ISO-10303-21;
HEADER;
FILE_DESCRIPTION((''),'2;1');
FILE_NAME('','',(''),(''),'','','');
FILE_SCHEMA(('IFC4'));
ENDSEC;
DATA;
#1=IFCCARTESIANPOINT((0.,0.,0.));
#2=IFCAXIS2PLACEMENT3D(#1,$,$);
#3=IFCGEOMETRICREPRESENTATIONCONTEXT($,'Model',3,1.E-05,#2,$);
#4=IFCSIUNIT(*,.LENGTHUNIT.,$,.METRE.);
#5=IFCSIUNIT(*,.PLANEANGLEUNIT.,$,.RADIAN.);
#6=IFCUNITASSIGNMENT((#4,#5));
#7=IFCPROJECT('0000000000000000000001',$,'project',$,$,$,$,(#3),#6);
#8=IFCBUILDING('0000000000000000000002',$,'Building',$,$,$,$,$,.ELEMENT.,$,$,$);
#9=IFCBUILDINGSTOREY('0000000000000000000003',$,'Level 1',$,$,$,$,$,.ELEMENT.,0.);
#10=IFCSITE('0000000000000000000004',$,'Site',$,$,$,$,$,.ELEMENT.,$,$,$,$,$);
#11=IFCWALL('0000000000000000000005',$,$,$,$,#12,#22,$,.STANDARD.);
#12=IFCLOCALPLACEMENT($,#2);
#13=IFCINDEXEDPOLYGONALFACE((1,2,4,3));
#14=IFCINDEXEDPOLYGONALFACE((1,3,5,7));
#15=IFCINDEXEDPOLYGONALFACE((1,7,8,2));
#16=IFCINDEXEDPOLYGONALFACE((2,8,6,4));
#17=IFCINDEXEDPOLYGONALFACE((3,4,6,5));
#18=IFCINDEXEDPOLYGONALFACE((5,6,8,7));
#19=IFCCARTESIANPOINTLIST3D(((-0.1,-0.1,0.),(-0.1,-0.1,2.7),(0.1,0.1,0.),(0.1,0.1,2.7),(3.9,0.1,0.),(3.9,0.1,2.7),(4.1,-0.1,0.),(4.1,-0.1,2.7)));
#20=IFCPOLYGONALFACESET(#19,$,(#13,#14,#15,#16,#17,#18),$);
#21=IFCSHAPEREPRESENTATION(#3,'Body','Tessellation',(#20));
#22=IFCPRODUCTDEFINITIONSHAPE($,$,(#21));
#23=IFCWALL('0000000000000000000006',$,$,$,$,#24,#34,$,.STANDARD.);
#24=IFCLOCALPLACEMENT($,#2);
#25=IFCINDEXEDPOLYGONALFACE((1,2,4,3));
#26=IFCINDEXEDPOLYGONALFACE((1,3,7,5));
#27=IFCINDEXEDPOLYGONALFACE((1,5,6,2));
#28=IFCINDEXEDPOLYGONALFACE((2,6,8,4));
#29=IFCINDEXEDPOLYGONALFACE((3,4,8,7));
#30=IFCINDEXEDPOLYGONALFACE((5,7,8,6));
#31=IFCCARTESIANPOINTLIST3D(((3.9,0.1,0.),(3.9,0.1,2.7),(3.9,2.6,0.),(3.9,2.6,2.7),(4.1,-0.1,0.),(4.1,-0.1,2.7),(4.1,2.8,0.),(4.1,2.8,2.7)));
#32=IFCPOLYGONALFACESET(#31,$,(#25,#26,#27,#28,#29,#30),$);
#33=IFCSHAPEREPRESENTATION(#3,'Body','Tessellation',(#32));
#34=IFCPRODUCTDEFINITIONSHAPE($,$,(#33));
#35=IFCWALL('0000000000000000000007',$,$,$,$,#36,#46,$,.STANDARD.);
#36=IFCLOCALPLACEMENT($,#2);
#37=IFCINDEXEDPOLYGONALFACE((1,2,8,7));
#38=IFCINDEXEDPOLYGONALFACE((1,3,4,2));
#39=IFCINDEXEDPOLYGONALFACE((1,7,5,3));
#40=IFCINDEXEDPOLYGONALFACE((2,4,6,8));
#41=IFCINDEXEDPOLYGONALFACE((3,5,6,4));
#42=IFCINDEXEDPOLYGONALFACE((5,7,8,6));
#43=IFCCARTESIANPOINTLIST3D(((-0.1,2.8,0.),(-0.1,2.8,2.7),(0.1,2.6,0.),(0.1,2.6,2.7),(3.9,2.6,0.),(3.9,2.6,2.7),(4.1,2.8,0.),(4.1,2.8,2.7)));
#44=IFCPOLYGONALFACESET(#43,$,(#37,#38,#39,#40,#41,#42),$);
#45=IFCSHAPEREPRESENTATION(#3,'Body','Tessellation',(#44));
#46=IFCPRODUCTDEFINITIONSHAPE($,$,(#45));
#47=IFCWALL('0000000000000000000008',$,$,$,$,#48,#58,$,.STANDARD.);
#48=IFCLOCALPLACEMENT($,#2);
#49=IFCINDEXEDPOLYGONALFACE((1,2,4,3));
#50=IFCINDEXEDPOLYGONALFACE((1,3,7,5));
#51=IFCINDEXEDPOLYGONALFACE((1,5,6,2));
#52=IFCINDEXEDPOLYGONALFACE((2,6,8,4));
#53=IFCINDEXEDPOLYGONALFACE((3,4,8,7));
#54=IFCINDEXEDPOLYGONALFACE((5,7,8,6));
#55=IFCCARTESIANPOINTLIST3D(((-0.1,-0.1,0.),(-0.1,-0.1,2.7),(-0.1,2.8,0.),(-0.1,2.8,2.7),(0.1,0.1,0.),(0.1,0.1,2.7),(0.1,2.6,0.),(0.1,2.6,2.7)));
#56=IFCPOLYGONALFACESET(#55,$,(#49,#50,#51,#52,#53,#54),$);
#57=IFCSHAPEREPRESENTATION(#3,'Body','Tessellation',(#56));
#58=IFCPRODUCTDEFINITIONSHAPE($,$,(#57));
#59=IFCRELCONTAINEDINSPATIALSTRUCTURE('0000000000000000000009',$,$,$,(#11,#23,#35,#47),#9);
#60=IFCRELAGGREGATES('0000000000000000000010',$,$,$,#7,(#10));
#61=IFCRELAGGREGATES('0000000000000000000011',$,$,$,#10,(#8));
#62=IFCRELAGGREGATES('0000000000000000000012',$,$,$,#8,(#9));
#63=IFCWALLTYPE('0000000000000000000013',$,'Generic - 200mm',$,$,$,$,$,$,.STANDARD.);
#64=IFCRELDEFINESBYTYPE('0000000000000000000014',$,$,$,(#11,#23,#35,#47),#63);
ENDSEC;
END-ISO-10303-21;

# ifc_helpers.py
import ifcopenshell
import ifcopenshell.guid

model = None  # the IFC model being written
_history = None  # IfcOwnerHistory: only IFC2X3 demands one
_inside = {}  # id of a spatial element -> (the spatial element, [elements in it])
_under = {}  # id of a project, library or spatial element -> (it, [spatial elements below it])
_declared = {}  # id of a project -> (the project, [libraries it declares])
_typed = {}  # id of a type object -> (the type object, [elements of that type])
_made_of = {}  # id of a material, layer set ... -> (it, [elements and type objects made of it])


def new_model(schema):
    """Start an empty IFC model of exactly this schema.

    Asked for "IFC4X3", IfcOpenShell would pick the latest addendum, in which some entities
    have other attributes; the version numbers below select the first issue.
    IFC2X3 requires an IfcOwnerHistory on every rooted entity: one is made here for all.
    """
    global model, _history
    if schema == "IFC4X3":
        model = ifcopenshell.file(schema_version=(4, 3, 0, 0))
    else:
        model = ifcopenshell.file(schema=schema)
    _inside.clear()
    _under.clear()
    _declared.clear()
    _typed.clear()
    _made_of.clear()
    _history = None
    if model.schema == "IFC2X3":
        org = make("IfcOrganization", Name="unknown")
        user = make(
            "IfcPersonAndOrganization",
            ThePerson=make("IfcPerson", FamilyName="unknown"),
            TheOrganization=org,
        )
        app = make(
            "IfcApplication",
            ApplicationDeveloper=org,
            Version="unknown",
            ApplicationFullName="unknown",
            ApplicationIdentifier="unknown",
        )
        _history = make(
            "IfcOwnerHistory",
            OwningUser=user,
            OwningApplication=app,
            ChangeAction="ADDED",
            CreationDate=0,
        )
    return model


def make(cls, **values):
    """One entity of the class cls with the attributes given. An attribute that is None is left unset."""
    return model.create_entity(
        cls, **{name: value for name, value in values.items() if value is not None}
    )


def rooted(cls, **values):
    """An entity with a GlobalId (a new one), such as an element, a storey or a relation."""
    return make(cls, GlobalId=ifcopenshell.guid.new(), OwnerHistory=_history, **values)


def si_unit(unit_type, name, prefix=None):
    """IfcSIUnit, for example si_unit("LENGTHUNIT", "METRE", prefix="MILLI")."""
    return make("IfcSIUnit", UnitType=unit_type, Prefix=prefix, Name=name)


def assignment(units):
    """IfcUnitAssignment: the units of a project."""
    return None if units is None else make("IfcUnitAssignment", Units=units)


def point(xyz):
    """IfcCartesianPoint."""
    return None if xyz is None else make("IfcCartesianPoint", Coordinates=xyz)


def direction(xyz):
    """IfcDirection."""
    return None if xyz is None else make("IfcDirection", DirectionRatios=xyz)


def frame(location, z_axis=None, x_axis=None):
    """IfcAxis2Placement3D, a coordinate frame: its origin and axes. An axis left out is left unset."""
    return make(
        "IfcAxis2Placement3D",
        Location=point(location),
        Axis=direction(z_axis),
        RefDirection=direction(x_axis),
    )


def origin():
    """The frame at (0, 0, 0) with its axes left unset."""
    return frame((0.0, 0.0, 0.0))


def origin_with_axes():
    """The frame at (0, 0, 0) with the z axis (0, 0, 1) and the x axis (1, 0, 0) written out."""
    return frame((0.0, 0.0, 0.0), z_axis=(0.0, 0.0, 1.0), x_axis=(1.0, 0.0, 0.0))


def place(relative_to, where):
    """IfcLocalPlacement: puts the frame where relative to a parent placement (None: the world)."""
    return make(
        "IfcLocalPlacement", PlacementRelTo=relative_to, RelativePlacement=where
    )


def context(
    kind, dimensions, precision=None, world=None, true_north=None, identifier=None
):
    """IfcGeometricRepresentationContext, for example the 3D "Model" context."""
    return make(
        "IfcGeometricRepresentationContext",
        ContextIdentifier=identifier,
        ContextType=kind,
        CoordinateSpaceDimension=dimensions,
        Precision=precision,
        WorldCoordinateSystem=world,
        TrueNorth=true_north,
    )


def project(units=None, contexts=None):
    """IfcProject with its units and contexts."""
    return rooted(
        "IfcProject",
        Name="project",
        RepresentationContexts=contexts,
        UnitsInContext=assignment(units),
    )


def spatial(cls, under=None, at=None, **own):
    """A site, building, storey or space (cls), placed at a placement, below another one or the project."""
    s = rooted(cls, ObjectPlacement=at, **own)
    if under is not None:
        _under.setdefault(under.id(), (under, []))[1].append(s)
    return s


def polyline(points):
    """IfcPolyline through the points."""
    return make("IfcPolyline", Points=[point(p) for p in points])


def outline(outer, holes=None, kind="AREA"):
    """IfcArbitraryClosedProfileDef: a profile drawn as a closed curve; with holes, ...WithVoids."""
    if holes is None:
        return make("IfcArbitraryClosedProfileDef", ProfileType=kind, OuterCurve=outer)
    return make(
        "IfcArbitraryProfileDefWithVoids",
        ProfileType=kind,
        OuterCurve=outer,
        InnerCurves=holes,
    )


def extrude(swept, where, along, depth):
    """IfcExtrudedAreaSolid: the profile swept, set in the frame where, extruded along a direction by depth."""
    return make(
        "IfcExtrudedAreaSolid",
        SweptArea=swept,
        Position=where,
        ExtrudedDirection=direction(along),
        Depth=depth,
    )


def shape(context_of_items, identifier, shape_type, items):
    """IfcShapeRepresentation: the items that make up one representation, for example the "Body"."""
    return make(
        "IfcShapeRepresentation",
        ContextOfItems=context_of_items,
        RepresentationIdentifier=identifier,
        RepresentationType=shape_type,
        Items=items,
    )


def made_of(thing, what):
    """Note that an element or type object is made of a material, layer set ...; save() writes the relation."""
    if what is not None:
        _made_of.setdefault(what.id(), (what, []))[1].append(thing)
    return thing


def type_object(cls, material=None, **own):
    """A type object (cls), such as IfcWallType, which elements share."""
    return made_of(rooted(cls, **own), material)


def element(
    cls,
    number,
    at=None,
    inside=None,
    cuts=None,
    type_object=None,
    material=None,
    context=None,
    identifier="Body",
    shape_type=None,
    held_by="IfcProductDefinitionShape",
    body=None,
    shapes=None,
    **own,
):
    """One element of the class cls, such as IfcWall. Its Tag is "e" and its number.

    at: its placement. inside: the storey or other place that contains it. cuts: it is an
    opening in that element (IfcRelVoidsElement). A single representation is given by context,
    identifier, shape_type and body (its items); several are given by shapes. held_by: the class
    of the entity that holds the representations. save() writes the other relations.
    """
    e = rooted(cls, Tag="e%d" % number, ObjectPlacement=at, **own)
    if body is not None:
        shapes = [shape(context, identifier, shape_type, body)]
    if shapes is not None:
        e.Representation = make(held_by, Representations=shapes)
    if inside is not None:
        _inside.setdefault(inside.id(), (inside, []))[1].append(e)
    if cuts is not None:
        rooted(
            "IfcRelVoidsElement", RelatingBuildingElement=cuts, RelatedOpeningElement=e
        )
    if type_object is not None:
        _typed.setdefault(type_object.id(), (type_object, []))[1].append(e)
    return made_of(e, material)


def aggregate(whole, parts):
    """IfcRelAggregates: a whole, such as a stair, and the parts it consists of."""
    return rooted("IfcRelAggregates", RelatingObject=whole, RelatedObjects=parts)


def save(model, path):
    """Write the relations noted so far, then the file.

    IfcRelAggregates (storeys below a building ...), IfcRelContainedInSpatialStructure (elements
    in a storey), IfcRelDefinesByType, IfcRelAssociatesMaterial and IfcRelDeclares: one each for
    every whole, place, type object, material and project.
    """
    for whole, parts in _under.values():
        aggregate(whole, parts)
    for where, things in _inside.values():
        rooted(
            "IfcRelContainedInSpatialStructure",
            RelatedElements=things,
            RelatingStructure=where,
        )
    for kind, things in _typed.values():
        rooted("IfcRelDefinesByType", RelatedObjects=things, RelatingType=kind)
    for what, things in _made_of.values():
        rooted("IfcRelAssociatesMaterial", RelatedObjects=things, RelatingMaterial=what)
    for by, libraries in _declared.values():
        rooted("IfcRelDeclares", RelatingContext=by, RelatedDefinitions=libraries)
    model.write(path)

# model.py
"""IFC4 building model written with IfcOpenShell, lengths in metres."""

from ifc_helpers import new_model, si_unit, frame, origin, origin_with_axes, place, context, project, spatial, polyline, outline, extrude, type_object, element, save


model = new_model("IFC4")

# Units and contexts
model_context = context("Model", 3, precision=1e-05, world=origin())
ifc_project = project(units=[si_unit("LENGTHUNIT", "METRE"), si_unit("PLANEANGLEUNIT", "RADIAN")], contexts=[model_context])

# Site, building, storey
site = spatial("IfcSite", under=ifc_project, Name="Site", CompositionType="ELEMENT")
building = spatial("IfcBuilding", under=site, Name="Building", CompositionType="ELEMENT")
storey = spatial("IfcBuildingStorey", under=building, Name="Level 1", CompositionType="ELEMENT", Elevation=0.0)

# Walls
wall_type = type_object("IfcWallType", Name="Generic - 200mm", PredefinedType="STANDARD")
wall_1_placement = place(None, origin_with_axes())
element("IfcWall", 1, at=wall_1_placement, inside=storey, type_object=wall_type, PredefinedType="STANDARD", context=model_context, shape_type="SweptSolid", body=[
    extrude(outline(polyline([(-0.1, -0.1), (4.1, -0.1), (3.9, 0.1), (0.1, 0.1), (-0.1, -0.1)])), origin(), (0.0, 0.0, 1.0), 2.7),
])
wall_2_placement = place(None, frame((4.0, 0.0, 0.0), z_axis=(0.0, 0.0, 1.0), x_axis=(0.0, 1.0, 0.0)))
element("IfcWall", 2, at=wall_2_placement, inside=storey, type_object=wall_type, PredefinedType="STANDARD", context=model_context, shape_type="SweptSolid", body=[
    extrude(outline(polyline([(-0.1, -0.1), (2.8, -0.1), (2.6, 0.1), (0.1, 0.1), (-0.1, -0.1)])), origin(), (0.0, 0.0, 1.0), 2.7),
])
wall_3_placement = place(None, frame((4.0, 2.7, 0.0), z_axis=(0.0, 0.0, 1.0), x_axis=(-1.0, 0.0, 0.0)))
element("IfcWall", 3, at=wall_3_placement, inside=storey, type_object=wall_type, PredefinedType="STANDARD", context=model_context, shape_type="SweptSolid", body=[
    extrude(outline(polyline([(-0.1, -0.1), (4.1, -0.1), (3.9, 0.1), (0.1, 0.1), (-0.1, -0.1)])), origin(), (0.0, 0.0, 1.0), 2.7),
])
wall_4_placement = place(None, frame((0.0, 2.7, 0.0), z_axis=(0.0, 0.0, 1.0), x_axis=(0.0, -1.0, 0.0)))
element("IfcWall", 4, at=wall_4_placement, inside=storey, type_object=wall_type, PredefinedType="STANDARD", context=model_context, shape_type="SweptSolid", body=[
    extrude(outline(polyline([(-0.1, -0.1), (2.8, -0.1), (2.6, 0.1), (0.1, 0.1), (-0.1, -0.1)])), origin(), (0.0, 0.0, 1.0), 2.7),
])

save(model, "model.ifc")
